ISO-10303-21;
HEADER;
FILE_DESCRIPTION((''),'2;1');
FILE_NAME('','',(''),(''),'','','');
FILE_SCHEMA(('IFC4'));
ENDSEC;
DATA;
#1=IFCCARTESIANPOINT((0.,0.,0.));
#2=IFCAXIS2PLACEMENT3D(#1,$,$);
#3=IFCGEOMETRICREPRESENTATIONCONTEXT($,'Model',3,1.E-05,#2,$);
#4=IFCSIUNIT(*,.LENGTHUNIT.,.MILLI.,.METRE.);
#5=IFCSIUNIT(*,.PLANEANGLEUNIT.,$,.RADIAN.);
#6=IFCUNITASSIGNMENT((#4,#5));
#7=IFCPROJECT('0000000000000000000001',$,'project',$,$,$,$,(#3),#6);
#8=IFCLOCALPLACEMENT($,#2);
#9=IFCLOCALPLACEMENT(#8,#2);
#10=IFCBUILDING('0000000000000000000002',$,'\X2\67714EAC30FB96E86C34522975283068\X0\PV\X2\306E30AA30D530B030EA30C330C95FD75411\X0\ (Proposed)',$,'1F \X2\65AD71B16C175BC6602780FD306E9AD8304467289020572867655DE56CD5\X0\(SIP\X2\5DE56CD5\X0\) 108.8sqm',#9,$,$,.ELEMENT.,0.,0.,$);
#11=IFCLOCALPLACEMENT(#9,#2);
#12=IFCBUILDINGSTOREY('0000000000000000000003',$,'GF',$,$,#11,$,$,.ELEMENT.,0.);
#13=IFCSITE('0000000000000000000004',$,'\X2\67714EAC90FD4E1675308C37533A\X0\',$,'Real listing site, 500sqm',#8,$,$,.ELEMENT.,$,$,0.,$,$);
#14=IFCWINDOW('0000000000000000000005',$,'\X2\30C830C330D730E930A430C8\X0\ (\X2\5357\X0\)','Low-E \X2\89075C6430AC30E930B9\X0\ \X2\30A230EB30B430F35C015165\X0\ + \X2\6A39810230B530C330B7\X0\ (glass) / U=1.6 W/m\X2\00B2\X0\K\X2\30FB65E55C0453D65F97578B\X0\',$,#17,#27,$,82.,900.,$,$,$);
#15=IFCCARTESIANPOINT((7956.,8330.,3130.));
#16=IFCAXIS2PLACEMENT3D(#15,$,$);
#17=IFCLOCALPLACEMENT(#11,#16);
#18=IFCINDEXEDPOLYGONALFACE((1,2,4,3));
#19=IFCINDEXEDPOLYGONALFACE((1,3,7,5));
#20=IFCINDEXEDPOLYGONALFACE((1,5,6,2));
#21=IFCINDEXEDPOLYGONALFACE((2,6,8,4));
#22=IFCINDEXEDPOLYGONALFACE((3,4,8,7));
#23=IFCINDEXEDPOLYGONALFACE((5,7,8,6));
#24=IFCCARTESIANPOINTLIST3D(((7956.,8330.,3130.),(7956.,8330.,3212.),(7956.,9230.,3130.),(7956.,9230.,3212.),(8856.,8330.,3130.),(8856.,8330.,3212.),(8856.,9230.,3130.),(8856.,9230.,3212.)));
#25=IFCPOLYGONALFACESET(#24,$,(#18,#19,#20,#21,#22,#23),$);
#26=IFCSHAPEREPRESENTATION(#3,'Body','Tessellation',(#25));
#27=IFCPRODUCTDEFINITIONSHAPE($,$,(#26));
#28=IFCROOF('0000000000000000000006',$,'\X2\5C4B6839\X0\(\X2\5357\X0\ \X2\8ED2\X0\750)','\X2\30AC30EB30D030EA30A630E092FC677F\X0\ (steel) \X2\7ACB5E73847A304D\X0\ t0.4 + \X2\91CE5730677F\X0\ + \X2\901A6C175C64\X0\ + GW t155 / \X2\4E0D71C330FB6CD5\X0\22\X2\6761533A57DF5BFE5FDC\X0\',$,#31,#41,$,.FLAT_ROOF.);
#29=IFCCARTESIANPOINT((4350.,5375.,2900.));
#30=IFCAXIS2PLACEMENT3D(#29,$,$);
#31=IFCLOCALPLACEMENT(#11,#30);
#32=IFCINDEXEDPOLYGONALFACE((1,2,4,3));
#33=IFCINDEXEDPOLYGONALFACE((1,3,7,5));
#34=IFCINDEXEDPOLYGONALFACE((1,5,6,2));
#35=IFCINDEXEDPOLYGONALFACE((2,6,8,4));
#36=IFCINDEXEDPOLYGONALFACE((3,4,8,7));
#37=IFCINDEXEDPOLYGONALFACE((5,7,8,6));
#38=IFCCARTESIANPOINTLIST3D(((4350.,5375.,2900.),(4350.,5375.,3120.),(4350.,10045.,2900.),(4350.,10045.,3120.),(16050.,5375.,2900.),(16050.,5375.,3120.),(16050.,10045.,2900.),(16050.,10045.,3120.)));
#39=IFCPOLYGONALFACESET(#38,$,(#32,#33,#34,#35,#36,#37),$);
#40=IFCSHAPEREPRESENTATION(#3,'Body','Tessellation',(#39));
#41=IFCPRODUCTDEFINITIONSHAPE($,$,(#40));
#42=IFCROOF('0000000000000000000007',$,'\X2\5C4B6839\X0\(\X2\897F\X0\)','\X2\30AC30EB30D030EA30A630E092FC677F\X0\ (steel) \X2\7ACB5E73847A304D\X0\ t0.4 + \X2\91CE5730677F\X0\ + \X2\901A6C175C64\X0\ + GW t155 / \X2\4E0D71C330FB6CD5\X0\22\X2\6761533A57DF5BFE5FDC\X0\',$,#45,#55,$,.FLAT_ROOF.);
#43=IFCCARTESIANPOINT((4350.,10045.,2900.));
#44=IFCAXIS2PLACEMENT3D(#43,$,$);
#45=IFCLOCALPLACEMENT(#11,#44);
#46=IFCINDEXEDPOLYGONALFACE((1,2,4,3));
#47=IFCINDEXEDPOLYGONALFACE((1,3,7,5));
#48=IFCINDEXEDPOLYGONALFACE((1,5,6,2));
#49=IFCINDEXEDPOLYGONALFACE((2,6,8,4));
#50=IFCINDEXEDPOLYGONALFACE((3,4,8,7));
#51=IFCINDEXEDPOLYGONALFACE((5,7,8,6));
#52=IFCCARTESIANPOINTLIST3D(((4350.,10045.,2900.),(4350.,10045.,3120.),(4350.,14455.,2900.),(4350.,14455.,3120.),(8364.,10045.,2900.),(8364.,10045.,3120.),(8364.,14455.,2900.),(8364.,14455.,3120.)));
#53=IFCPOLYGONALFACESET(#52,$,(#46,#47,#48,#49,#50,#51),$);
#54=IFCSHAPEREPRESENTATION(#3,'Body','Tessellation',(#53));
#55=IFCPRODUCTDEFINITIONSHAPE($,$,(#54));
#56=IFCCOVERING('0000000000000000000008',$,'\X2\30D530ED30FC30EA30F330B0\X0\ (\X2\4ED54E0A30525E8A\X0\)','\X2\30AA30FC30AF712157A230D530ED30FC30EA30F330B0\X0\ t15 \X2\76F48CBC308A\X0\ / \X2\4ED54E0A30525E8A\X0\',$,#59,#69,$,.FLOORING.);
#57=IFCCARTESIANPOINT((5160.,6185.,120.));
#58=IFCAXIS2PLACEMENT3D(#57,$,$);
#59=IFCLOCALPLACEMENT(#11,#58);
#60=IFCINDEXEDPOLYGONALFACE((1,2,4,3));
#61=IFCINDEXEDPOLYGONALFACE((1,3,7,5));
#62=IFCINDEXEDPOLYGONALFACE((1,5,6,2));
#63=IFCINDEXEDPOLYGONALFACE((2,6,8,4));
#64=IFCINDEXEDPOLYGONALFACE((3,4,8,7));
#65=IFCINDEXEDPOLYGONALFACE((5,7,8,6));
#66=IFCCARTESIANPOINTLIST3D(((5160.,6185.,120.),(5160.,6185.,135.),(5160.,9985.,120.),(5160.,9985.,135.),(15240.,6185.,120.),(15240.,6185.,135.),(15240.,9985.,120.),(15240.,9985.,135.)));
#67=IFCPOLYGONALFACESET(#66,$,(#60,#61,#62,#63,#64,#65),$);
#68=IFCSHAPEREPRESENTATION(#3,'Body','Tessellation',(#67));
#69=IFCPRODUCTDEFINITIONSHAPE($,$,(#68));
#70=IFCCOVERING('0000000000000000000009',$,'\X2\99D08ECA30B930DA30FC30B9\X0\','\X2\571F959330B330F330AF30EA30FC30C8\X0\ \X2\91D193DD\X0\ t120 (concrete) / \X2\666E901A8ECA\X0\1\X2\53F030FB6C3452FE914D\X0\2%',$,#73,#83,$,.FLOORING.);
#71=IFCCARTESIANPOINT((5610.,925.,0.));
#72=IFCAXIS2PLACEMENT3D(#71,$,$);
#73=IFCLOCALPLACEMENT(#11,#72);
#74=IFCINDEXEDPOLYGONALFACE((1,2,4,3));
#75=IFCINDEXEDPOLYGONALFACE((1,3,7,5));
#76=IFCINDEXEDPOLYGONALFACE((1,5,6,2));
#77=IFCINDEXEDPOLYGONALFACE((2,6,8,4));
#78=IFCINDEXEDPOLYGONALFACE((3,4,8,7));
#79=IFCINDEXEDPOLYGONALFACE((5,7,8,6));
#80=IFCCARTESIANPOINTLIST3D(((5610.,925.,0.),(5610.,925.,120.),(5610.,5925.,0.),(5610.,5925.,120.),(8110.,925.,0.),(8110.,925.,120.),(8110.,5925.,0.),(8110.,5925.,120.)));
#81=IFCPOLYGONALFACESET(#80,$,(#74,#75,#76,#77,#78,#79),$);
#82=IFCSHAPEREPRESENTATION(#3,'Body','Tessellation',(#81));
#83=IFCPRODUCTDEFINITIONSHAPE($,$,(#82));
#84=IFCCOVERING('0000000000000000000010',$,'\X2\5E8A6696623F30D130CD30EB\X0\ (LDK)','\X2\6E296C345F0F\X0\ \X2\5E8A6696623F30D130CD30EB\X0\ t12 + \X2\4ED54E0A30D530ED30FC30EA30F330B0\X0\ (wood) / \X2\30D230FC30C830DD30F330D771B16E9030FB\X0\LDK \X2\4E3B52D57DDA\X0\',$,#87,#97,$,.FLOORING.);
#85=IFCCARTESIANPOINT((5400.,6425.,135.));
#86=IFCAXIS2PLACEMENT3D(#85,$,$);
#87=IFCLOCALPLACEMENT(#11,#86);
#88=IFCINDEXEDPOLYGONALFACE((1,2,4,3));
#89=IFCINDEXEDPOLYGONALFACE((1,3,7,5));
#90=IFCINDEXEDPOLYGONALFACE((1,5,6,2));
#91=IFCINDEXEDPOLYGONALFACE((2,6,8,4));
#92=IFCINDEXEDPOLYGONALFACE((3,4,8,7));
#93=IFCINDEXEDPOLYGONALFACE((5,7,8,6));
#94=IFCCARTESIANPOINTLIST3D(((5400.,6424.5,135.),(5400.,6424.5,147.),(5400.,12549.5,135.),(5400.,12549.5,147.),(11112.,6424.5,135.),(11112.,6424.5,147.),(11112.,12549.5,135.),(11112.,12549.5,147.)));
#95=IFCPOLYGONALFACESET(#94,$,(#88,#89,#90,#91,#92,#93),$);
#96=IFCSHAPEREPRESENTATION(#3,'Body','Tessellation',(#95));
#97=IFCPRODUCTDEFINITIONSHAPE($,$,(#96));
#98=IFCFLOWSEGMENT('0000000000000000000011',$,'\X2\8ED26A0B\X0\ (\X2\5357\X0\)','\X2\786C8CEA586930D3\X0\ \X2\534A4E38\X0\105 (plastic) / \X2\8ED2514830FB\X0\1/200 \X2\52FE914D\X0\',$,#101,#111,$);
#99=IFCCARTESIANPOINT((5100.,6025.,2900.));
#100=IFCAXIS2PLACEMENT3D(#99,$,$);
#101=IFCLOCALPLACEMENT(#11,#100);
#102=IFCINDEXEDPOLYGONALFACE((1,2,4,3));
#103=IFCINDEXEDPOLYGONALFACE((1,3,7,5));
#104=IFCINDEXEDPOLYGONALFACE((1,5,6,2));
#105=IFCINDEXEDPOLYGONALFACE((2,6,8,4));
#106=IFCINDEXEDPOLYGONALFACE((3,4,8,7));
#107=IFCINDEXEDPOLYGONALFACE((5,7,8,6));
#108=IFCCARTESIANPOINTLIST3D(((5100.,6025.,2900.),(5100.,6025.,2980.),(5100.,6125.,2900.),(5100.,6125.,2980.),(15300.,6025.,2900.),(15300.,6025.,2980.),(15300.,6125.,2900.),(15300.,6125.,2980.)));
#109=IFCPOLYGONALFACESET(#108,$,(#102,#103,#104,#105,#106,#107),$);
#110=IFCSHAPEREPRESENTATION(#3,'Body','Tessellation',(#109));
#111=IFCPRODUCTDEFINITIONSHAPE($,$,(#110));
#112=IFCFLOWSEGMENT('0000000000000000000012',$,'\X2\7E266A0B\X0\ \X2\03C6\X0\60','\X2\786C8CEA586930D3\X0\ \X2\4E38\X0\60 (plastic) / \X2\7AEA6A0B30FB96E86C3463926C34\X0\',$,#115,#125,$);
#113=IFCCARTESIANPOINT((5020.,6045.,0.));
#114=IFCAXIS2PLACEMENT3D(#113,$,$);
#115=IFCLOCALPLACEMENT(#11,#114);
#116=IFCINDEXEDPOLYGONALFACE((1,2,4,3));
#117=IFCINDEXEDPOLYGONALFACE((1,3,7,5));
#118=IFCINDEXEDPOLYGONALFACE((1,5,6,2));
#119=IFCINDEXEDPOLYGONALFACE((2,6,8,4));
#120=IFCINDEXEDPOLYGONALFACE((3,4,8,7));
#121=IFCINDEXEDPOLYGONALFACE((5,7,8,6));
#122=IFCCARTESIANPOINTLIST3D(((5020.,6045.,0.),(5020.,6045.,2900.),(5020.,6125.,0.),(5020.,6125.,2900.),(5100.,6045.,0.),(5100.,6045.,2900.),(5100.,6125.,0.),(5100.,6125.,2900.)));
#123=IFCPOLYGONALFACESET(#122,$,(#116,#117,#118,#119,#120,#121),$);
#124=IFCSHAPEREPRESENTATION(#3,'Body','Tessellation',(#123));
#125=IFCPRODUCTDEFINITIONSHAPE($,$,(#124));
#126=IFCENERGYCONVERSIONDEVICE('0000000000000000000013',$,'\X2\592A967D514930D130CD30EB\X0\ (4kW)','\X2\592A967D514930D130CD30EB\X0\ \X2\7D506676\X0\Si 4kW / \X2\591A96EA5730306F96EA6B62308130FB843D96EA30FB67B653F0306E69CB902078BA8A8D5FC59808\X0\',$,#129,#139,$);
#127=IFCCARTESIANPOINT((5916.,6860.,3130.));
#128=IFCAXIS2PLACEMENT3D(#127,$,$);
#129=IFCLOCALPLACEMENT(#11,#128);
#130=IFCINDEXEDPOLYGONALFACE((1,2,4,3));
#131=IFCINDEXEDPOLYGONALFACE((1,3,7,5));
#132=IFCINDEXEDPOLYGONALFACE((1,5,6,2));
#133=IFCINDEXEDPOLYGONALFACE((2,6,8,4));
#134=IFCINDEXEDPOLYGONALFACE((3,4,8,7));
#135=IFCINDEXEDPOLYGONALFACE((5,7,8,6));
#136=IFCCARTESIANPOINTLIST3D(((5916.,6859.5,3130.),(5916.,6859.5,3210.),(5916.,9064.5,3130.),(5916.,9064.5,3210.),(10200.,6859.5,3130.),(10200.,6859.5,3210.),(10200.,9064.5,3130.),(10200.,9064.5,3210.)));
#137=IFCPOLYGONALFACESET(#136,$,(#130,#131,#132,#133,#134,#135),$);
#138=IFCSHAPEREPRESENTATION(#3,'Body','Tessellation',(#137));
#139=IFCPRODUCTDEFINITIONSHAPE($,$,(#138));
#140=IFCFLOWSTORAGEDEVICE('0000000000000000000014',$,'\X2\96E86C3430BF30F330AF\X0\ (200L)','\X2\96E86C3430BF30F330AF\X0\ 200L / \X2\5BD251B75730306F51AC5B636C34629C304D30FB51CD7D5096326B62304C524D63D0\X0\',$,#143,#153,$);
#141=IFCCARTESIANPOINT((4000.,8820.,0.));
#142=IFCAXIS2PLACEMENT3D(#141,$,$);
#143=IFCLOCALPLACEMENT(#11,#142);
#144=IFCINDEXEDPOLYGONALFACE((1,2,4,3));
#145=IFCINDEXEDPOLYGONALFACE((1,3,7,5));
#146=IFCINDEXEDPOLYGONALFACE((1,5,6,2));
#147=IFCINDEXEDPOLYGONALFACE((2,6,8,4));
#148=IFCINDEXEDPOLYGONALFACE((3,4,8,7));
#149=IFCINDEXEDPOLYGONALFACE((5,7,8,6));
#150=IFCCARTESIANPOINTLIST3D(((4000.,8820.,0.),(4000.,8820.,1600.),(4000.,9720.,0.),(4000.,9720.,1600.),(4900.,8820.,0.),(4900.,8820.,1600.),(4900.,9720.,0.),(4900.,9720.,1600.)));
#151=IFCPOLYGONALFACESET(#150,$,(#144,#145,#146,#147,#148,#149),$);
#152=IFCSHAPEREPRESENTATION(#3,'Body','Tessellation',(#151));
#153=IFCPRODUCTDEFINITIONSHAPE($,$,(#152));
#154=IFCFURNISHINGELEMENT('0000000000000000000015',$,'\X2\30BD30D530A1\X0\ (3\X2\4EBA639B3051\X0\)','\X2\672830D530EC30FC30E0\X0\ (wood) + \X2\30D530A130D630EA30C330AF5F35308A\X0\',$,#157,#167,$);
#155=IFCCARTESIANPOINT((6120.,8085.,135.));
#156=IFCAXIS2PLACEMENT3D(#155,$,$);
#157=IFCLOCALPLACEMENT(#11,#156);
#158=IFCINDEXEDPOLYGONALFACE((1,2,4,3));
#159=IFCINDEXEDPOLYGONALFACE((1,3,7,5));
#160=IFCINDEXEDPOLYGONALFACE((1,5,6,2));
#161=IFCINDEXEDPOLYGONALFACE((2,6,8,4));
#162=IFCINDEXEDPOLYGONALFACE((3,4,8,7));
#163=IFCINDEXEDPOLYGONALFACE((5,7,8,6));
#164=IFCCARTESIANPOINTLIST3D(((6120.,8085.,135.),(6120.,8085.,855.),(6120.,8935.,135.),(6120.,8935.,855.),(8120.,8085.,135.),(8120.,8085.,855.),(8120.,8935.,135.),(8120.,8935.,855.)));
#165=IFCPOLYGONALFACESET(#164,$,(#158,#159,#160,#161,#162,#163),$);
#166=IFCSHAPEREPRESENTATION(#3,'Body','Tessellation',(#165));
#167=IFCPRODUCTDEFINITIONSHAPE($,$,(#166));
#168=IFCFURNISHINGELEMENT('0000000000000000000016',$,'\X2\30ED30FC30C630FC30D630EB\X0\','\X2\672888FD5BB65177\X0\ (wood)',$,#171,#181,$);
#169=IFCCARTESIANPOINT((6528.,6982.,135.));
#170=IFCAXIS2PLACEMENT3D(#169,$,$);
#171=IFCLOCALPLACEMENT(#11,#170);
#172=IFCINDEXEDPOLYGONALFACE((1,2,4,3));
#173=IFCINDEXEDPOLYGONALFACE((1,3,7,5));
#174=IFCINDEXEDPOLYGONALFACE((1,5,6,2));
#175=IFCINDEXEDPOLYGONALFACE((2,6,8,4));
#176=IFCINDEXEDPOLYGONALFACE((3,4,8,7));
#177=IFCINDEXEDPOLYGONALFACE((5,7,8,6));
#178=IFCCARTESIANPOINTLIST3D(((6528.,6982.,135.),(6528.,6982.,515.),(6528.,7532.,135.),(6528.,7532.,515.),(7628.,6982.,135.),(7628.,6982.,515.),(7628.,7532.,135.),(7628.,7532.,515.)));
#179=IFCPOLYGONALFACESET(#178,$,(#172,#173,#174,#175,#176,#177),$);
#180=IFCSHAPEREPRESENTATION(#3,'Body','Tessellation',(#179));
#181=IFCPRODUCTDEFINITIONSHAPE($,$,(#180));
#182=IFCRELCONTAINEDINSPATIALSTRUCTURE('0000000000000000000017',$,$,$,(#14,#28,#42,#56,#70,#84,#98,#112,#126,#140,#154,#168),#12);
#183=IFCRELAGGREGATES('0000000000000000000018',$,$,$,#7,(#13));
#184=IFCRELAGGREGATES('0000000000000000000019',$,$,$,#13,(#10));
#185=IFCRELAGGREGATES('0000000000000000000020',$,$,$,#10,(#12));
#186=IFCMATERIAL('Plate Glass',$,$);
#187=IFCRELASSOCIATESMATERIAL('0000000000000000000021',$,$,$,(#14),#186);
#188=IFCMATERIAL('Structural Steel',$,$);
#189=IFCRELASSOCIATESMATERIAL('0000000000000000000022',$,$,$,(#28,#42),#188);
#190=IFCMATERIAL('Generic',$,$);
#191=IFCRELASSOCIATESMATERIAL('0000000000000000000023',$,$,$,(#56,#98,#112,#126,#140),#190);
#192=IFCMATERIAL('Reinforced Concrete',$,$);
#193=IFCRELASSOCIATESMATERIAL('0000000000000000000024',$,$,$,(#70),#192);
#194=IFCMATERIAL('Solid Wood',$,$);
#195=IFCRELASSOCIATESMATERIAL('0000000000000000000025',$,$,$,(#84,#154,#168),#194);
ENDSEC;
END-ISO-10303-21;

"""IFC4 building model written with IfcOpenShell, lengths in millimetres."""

from ifc_helpers import new_model, si_unit, frame, frame_2d, origin, place, context, project, spatial, rectangle, extrude, material, element, save


model = new_model("IFC4")

# Units and contexts
model_context = context("Model", 3, precision=1e-05, world=origin())
ifc_project = project(units=[si_unit("LENGTHUNIT", "METRE", prefix="MILLI"), si_unit("PLANEANGLEUNIT", "RADIAN")], contexts=[model_context])

# Site, building, storey
site_placement = place(None, origin())
site = spatial("IfcSite", under=ifc_project, at=site_placement, Name="東京都世田谷区", ObjectType="Real listing site, 500sqm", CompositionType="ELEMENT", RefElevation=0.0)
building_placement = place(site_placement, origin())
building = spatial("IfcBuilding", under=site, at=building_placement, Name="東京・雨水利用とPVのオフグリッド志向 (Proposed)", ObjectType="1F 断熱気密性能の高い木造在来工法(SIP工法) 108.8sqm", CompositionType="ELEMENT", ElevationOfRefHeight=0.0, ElevationOfTerrain=0.0)
storey_placement = place(building_placement, origin())
storey = spatial("IfcBuildingStorey", under=building, at=storey_placement, Name="GF", CompositionType="ELEMENT", Elevation=0.0)

# Shared definitions
ifc_material_1 = material(Name="Solid Wood")

# Shared definitions
ifc_material_2 = material(Name="Reinforced Concrete")

# Shared definitions
ifc_material_3 = material(Name="Plate Glass")

# Window
window_1_placement = place(storey_placement, frame((7956.0, 8330.0, 3130.0)))
element("IfcWindow", 1, at=window_1_placement, inside=storey, material=ifc_material_3, Name="トップライト (南)", Description="Low-E 複層ガラス アルゴン封入 + 樹脂サッシ (glass) / U=1.6 W/m²K・日射取得型", OverallHeight=82.0, OverallWidth=900.0, context=model_context, shape_type="SweptSolid", body=[
    extrude(rectangle(XDim=900.0, YDim=900.0, at=frame_2d((450.0, 450.0))), frame((7956.0, 8330.0, 3130.0)), (0.0, 0.0, 1.0), 82.0),
])

# Roofs
ifc_material_4 = material(Name="Structural Steel")
roof_1_placement = place(storey_placement, frame((4350.0, 5375.0, 2900.0)))
element("IfcRoof", 2, at=roof_1_placement, inside=storey, material=ifc_material_4, Name="屋根(南 軒750)", Description="ガルバリウム鋼板 (steel) 立平葺き t0.4 + 野地板 + 通気層 + GW t155 / 不燃・法22条区域対応", PredefinedType="FLAT_ROOF", context=model_context, shape_type="SweptSolid", body=[
    extrude(rectangle(XDim=11700.0, YDim=4670.0, at=frame_2d((5850.0, 2335.0))), frame((4350.0, 5375.0, 2900.0)), (0.0, 0.0, 1.0), 220.0),
])
roof_2_placement = place(storey_placement, frame((4350.0, 10045.0, 2900.0)))
element("IfcRoof", 3, at=roof_2_placement, inside=storey, material=ifc_material_4, Name="屋根(西)", Description="ガルバリウム鋼板 (steel) 立平葺き t0.4 + 野地板 + 通気層 + GW t155 / 不燃・法22条区域対応", PredefinedType="FLAT_ROOF", context=model_context, shape_type="SweptSolid", body=[
    extrude(rectangle(XDim=4014.0, YDim=4410.0, at=frame_2d((2007.0, 2205.0))), frame((4350.0, 10045.0, 2900.0)), (0.0, 0.0, 1.0), 220.0),
])

# Coverings
ifc_material_5 = material(Name="Generic")
covering_1_placement = place(storey_placement, frame((5160.0, 6185.0, 120.0)))
element("IfcCovering", 4, at=covering_1_placement, inside=storey, material=ifc_material_5, Name="フローリング (仕上げ床)", Description="オーク無垢フローリング t15 直貼り / 仕上げ床", PredefinedType="FLOORING", context=model_context, shape_type="SweptSolid", body=[
    extrude(rectangle(XDim=10080.0, YDim=3800.0, at=frame_2d((5040.0, 1900.0))), frame((5160.0, 6185.0, 120.0)), (0.0, 0.0, 1.0), 15.0),
])
covering_2_placement = place(storey_placement, frame((5610.0, 925.0, 0.0)))
element("IfcCovering", 5, at=covering_2_placement, inside=storey, material=ifc_material_2, Name="駐車スペース", Description="土間コンクリート 金鏝 t120 (concrete) / 普通車1台・水勾配2%", PredefinedType="FLOORING", context=model_context, shape_type="SweptSolid", body=[
    extrude(rectangle(XDim=2500.0, YDim=5000.0, at=frame_2d((1250.0, 2500.0))), frame((5610.0, 925.0, 0.0)), (0.0, 0.0, 1.0), 120.0),
])
covering_3_placement = place(storey_placement, frame((5400.0, 6425.0, 135.0)))
element("IfcCovering", 6, at=covering_3_placement, inside=storey, material=ifc_material_1, Name="床暖房パネル (LDK)", Description="温水式 床暖房パネル t12 + 仕上フローリング (wood) / ヒートポンプ熱源・LDK 主動線", PredefinedType="FLOORING", context=model_context, shape_type="SweptSolid", body=[
    extrude(rectangle(XDim=5712.0, YDim=6125.0, at=frame_2d((2856.0, 3062.0))), frame((5400.0, 6425.0, 135.0)), (0.0, 0.0, 1.0), 12.0),
])

# Flow segments
flow_segment_1_placement = place(storey_placement, frame((5100.0, 6025.0, 2900.0)))
element("IfcFlowSegment", 7, at=flow_segment_1_placement, inside=storey, material=ifc_material_5, Name="軒樋 (南)", Description="硬質塩ビ 半丸105 (plastic) / 軒先・1/200 勾配", context=model_context, shape_type="SweptSolid", body=[
    extrude(rectangle(XDim=10200.0, YDim=100.0, at=frame_2d((5100.0, 50.0))), frame((5100.0, 6025.0, 2900.0)), (0.0, 0.0, 1.0), 80.0),
])
flow_segment_2_placement = place(storey_placement, frame((5020.0, 6045.0, 0.0)))
element("IfcFlowSegment", 8, at=flow_segment_2_placement, inside=storey, material=ifc_material_5, Name="縦樋 φ60", Description="硬質塩ビ 丸60 (plastic) / 竪樋・雨水排水", context=model_context, shape_type="SweptSolid", body=[
    extrude(rectangle(XDim=80.0, YDim=80.0, at=frame_2d((40.0, 40.0))), frame((5020.0, 6045.0, 0.0)), (0.0, 0.0, 1.0), 2900.0),
])

# Energy conversion device
energy_conversion_device_placement = place(storey_placement, frame((5916.0, 6860.0, 3130.0)))
element("IfcEnergyConversionDevice", 9, at=energy_conversion_device_placement, inside=storey, material=ifc_material_5, Name="太陽光パネル (4kW)", Description="太陽光パネル 結晶Si 4kW / 多雪地は雪止め・落雪・架台の構造確認必須", context=model_context, shape_type="SweptSolid", body=[
    extrude(rectangle(XDim=4284.0, YDim=2205.0, at=frame_2d((2142.0, 1102.0))), frame((5916.0, 6860.0, 3130.0)), (0.0, 0.0, 1.0), 80.0),
])

# Flow storage device
flow_storage_device_placement = place(storey_placement, frame((4000.0, 8820.0, 0.0)))
element("IfcFlowStorageDevice", 10, at=flow_storage_device_placement, inside=storey, material=ifc_material_5, Name="雨水タンク (200L)", Description="雨水タンク 200L / 寒冷地は冬季水抜き・凍結防止が前提", context=model_context, shape_type="SweptSolid", body=[
    extrude(rectangle(XDim=900.0, YDim=900.0, at=frame_2d((450.0, 450.0))), frame((4000.0, 8820.0, 0.0)), (0.0, 0.0, 1.0), 1600.0),
])

# Furnishing elements
furnishing_1_placement = place(storey_placement, frame((6120.0, 8085.0, 135.0)))
element("IfcFurnishingElement", 11, at=furnishing_1_placement, inside=storey, material=ifc_material_1, Name="ソファ (3人掛け)", Description="木フレーム (wood) + ファブリック張り", context=model_context, shape_type="SweptSolid", body=[
    extrude(rectangle(XDim=2000.0, YDim=850.0, at=frame_2d((1000.0, 425.0))), frame((6120.0, 8085.0, 135.0)), (0.0, 0.0, 1.0), 720.0),
])
furnishing_2_placement = place(storey_placement, frame((6528.0, 6982.0, 135.0)))
element("IfcFurnishingElement", 12, at=furnishing_2_placement, inside=storey, material=ifc_material_1, Name="ローテーブル", Description="木製家具 (wood)", context=model_context, shape_type="SweptSolid", body=[
    extrude(rectangle(XDim=1100.0, YDim=550.0, at=frame_2d((550.0, 275.0))), frame((6528.0, 6982.0, 135.0)), (0.0, 0.0, 1.0), 380.0),
])

save(model, "model.ifc")
